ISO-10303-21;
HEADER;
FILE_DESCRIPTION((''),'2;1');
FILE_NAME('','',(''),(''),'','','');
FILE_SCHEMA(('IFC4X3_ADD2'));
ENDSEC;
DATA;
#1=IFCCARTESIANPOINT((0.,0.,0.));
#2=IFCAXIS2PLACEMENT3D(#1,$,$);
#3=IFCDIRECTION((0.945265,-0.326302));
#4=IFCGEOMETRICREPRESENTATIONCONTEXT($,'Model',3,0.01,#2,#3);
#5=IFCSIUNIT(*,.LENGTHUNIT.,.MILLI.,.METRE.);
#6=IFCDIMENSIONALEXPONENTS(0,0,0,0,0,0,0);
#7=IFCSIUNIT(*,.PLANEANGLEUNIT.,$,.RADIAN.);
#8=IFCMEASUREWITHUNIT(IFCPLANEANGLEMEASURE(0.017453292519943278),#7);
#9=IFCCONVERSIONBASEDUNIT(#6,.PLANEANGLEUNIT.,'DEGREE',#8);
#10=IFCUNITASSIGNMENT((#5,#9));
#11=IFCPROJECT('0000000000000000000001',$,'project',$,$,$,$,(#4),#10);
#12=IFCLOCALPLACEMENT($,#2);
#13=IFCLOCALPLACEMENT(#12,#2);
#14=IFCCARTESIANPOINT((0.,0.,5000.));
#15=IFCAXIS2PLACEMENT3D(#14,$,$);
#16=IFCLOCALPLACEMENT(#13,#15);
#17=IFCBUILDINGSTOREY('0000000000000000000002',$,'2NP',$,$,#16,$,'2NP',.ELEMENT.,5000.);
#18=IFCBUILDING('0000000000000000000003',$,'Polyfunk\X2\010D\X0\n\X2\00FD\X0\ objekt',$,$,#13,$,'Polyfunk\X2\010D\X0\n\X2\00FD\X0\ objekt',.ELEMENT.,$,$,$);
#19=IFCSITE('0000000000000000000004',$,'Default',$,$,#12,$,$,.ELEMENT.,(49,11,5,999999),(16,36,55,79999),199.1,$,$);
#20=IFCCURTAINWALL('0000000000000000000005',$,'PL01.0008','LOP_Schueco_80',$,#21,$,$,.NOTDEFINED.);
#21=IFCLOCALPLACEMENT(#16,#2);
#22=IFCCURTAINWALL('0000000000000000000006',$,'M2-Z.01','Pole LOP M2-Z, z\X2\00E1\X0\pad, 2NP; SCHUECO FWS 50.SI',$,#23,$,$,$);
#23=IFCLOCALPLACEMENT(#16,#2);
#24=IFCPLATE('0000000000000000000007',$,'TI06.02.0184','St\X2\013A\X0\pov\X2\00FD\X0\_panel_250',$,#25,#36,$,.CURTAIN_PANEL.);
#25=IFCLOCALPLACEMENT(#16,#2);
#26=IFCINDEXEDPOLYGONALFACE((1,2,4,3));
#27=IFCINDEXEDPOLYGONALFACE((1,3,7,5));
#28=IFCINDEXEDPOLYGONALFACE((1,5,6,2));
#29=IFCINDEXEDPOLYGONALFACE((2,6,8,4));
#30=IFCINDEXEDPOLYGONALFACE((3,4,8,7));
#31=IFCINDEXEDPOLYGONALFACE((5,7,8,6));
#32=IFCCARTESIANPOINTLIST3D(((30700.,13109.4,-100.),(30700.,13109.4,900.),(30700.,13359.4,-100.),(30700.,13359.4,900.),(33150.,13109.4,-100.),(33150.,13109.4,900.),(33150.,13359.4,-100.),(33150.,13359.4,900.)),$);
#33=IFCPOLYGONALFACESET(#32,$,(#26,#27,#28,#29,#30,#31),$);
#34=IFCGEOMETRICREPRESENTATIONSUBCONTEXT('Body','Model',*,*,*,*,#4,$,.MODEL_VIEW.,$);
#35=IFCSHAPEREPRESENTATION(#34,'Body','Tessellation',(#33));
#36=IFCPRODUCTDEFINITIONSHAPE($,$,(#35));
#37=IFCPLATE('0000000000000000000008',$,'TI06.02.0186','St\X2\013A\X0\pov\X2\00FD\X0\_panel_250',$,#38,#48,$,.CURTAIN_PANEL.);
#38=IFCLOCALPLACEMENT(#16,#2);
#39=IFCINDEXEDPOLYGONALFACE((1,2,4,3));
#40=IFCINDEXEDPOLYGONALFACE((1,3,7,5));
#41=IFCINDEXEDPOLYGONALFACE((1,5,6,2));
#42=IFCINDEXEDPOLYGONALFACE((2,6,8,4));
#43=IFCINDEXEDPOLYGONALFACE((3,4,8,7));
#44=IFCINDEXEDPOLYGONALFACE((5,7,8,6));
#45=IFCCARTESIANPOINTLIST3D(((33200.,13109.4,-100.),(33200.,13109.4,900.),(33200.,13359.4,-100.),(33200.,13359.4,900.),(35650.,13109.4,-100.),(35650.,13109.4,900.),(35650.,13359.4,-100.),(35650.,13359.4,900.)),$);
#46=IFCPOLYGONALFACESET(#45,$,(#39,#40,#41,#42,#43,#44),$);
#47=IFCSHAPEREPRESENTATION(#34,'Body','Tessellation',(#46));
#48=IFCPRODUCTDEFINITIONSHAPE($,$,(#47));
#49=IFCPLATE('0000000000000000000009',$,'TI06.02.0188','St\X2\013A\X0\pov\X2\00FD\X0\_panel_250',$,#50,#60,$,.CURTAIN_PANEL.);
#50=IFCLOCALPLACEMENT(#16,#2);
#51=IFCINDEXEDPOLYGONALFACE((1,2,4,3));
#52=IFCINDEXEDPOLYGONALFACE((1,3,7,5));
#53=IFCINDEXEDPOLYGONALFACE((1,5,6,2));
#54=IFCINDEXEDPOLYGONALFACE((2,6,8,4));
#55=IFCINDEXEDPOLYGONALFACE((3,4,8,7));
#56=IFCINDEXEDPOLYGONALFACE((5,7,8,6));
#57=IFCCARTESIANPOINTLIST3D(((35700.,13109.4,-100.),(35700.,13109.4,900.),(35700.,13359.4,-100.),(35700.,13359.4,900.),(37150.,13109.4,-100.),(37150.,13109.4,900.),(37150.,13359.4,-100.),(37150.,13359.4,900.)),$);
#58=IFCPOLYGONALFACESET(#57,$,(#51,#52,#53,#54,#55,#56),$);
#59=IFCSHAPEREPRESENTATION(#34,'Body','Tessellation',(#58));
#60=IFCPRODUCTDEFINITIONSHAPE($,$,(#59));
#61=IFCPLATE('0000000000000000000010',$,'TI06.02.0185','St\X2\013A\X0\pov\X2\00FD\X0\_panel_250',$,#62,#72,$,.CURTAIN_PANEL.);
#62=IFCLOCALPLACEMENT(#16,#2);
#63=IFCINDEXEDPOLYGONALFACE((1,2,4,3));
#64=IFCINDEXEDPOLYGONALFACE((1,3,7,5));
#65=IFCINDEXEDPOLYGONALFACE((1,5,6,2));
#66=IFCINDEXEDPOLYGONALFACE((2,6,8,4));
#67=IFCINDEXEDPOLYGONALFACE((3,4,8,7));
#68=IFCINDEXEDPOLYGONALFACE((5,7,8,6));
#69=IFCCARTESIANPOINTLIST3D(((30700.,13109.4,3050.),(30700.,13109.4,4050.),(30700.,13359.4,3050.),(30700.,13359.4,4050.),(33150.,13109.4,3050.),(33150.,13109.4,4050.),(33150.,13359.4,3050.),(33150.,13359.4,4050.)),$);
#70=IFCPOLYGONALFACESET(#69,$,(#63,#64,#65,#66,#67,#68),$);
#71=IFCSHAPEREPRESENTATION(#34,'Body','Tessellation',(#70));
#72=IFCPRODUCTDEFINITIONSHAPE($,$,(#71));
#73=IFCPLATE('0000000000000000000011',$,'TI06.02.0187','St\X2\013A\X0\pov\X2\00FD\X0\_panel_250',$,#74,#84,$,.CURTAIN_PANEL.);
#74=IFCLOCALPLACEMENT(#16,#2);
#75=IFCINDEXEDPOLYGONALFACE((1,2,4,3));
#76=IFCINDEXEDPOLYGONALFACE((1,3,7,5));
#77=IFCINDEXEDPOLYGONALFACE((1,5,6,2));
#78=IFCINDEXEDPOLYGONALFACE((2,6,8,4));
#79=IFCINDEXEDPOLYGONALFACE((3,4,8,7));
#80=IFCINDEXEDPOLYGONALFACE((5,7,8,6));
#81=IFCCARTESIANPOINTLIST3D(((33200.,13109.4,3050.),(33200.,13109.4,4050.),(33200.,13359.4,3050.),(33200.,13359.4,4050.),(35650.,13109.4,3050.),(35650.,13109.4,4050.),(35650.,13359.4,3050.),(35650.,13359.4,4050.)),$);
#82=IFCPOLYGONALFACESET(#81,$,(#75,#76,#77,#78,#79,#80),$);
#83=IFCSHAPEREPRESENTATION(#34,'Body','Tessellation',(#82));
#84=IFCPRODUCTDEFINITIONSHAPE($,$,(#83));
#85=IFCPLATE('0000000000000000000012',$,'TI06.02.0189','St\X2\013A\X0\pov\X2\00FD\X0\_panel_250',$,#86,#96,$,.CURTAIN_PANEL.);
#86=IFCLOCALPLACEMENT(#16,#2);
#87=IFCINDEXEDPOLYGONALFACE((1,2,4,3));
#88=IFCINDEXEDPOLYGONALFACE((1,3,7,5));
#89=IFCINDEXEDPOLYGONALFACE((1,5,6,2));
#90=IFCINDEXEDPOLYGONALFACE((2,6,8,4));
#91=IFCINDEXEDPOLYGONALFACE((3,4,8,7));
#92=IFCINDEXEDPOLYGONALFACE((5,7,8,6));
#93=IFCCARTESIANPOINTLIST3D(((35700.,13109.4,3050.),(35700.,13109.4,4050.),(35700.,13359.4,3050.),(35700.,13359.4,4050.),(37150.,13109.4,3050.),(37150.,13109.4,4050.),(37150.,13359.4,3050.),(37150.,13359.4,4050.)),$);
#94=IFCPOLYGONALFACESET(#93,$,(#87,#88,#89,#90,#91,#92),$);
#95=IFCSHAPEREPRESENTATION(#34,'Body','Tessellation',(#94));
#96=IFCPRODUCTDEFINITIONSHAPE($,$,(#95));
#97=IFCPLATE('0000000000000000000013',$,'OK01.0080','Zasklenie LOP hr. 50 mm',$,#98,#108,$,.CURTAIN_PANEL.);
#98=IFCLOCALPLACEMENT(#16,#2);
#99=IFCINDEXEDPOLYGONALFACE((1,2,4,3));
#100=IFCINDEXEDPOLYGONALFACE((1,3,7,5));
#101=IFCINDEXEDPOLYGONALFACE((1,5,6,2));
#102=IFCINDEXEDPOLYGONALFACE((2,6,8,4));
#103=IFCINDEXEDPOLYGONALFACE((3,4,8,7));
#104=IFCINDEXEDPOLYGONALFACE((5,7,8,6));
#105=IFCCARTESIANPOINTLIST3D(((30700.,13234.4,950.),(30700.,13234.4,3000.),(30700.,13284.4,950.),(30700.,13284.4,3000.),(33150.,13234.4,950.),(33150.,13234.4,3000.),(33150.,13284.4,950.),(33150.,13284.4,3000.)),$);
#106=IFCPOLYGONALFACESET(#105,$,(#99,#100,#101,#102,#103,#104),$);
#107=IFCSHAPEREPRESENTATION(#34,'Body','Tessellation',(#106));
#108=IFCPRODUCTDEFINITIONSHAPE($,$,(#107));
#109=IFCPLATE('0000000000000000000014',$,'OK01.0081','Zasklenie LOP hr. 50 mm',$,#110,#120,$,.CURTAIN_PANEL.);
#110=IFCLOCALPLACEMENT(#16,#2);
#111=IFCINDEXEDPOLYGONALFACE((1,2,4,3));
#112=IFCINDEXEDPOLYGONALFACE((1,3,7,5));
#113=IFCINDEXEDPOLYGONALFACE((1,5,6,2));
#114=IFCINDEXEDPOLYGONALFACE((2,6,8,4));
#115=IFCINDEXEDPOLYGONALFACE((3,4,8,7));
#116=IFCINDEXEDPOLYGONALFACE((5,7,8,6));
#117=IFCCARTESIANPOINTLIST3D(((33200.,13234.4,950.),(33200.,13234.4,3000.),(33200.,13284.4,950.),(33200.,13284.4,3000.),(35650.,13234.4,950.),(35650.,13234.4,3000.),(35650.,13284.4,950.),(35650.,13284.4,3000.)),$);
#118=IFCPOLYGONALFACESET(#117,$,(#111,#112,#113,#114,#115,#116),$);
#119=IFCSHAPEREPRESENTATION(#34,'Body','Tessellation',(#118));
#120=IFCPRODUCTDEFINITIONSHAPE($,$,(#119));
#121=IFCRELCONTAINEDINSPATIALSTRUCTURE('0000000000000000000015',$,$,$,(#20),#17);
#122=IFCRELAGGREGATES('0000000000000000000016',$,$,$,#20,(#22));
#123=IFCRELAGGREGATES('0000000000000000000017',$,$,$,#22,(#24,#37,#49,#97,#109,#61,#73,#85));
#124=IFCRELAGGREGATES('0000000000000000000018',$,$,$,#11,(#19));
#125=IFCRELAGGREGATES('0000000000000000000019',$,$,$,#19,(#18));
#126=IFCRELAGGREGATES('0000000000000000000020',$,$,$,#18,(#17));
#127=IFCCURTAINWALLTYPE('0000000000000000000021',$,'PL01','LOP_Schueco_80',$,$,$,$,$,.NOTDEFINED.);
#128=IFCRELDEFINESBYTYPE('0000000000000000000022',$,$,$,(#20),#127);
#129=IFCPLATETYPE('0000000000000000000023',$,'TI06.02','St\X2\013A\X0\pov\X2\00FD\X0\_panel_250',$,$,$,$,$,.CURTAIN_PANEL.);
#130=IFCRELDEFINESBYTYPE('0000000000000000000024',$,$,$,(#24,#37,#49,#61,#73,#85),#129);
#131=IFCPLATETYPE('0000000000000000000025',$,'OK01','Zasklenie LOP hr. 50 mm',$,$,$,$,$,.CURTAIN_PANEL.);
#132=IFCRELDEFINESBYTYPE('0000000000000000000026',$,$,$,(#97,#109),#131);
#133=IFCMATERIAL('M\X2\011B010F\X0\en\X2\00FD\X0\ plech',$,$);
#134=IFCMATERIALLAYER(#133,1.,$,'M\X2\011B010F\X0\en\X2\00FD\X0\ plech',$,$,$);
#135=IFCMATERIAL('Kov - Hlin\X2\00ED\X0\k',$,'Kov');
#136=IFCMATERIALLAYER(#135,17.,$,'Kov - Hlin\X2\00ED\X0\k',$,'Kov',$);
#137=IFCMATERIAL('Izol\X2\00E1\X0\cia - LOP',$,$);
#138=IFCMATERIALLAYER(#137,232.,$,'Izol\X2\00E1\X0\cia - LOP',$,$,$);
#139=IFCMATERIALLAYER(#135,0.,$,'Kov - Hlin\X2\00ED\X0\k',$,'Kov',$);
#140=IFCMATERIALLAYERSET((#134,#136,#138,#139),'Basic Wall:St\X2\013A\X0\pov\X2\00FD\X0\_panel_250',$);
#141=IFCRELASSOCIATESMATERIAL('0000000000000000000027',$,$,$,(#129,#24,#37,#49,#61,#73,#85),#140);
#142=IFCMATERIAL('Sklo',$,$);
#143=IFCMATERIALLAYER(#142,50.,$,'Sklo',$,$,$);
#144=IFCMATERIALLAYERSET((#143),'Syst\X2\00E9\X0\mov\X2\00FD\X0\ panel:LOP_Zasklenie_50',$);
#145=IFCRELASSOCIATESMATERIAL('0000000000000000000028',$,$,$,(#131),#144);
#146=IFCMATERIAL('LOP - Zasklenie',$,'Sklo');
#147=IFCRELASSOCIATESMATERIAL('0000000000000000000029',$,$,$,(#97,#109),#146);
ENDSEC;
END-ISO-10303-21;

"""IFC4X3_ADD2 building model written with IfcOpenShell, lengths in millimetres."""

from ifc_helpers import new_model, entity, si_unit, converted_unit, direction, frame, frame_2d, origin, origin_2d_with_axis, place, context, subcontext, project, spatial, rectangle, extrude, source, transform, mapped, material, layer, layer_set, layer_usage, type_object, type_shapes, element, aggregate, save


model = new_model("IFC4X3_ADD2")

# Units and contexts
model_context = context("Model", 3, precision=0.01, world=origin(), true_north=direction((0.945265, -0.326302)))
body_context = subcontext(model_context, "Body", "Model", "MODEL_VIEW")
ifc_project = project(units=[si_unit("LENGTHUNIT", "METRE", prefix="MILLI"), converted_unit("PLANEANGLEUNIT", "DEGREE", entity("IfcPlaneAngleMeasure", 0.017453292519943278), si_unit("PLANEANGLEUNIT", "RADIAN"), dimensions=[0, 0, 0, 0, 0, 0, 0])], contexts=[model_context])

# Site, building, storey
site_placement = place(None, origin())
site = spatial("IfcSite", under=ifc_project, at=site_placement, Name="Default", CompositionType="ELEMENT", RefLatitude=(49, 11, 5, 999999), RefLongitude=(16, 36, 55, 79999), RefElevation=199.1)
building_placement = place(site_placement, origin())
building = spatial("IfcBuilding", under=site, at=building_placement, Name="Polyfunkčný objekt", LongName="Polyfunkčný objekt", CompositionType="ELEMENT")
storey_placement = place(building_placement, frame((0.0, 0.0, 5000.0)))
storey = spatial("IfcBuildingStorey", under=building, at=storey_placement, Name="2NP", LongName="2NP", CompositionType="ELEMENT", Elevation=5000.0)

# Curtain walls, plates
curtain_wall_type = type_object("IfcCurtainWallType", Name="PL01", Description="LOP_Schueco_80", PredefinedType="NOTDEFINED")
curtain_wall_1_placement = place(storey_placement, frame((0.0, 0.0, -5000.0)))
curtain_wall_1 = element("IfcCurtainWall", 1, at=curtain_wall_1_placement, inside=storey, type_object=curtain_wall_type, Name="PL01.0008", Description="LOP_Schueco_80", PredefinedType="NOTDEFINED")
curtain_wall_2 = element("IfcCurtainWall", 2, Name="M2-Z.01", Description="Pole LOP M2-Z, západ, 2NP; SCHUECO FWS 50.SI")
aggregate(curtain_wall_1, [curtain_wall_2])
ifc_material_1 = material(Name="Měďený plech")
ifc_layer_1 = layer(ifc_material_1, 1.0, Name="Měďený plech")
ifc_material_2 = material(Name="Kov - Hliník", Category="Kov")
ifc_layer_2 = layer(ifc_material_2, 17.0, Name="Kov - Hliník", Category="Kov")
ifc_material_3 = material(Name="Izolácia - LOP")
ifc_layer_3 = layer(ifc_material_3, 232.0, Name="Izolácia - LOP")
ifc_layer_4 = layer(ifc_material_2, 0.0, Name="Kov - Hliník", Category="Kov")
ifc_layer_set_1 = layer_set([ifc_layer_1, ifc_layer_2, ifc_layer_3, ifc_layer_4], Name="Basic Wall:Stĺpový_panel_250")
ifc_layer_usage_1 = layer_usage(ifc_layer_set_1, "AXIS2", "NEGATIVE", 125.0)
plate_type_1 = type_object("IfcPlateType", Name="TI06.02", Description="Stĺpový_panel_250", PredefinedType="CURTAIN_PANEL", material=ifc_layer_set_1)
plate_1_placement = place(storey_placement, frame((30700.0, 13234.4, -100.0)))
plate_1 = element("IfcPlate", 3, at=plate_1_placement, type_object=plate_type_1, material=ifc_layer_usage_1, Name="TI06.02.0184", Description="Stĺpový_panel_250", PredefinedType="CURTAIN_PANEL", context=body_context, shape_type="SweptSolid", body=[
    extrude(rectangle(XDim=250.0, YDim=2450.0, at=frame_2d((0.0, 0.0), x_axis=(1.0, 0.0))), frame((1225.0, 0.0, 0.0), z_axis=(0.0, 0.0, 1.0), x_axis=(0.0, 1.0, 0.0)), (0.0, 0.0, 1.0), 1000.0),
])
ifc_layer_usage_2 = layer_usage(ifc_layer_set_1, "AXIS2", "NEGATIVE", 125.0)
plate_2_placement = place(storey_placement, frame((33200.0, 13234.4, -100.0)))
plate_2 = element("IfcPlate", 4, at=plate_2_placement, type_object=plate_type_1, material=ifc_layer_usage_2, Name="TI06.02.0186", Description="Stĺpový_panel_250", PredefinedType="CURTAIN_PANEL", context=body_context, shape_type="SweptSolid", body=[
    extrude(rectangle(XDim=250.0, YDim=2450.0, at=frame_2d((0.0, 0.0), x_axis=(1.0, 0.0))), frame((1225.0, 0.0, 0.0), z_axis=(0.0, 0.0, 1.0), x_axis=(0.0, 1.0, 0.0)), (0.0, 0.0, 1.0), 1000.0),
])
ifc_layer_usage_3 = layer_usage(ifc_layer_set_1, "AXIS2", "NEGATIVE", 125.0)
plate_3_placement = place(storey_placement, frame((35700.0, 13234.4, -100.0)))
plate_3 = element("IfcPlate", 5, at=plate_3_placement, type_object=plate_type_1, material=ifc_layer_usage_3, Name="TI06.02.0188", Description="Stĺpový_panel_250", PredefinedType="CURTAIN_PANEL", context=body_context, shape_type="SweptSolid", body=[
    extrude(rectangle(XDim=250.0, YDim=1450.0, at=origin_2d_with_axis()), frame((725.0, 0.0, 0.0), z_axis=(0.0, 0.0, 1.0), x_axis=(0.0, 1.0, 0.0)), (0.0, 0.0, 1.0), 1000.0),
])
ifc_layer_usage_4 = layer_usage(ifc_layer_set_1, "AXIS2", "NEGATIVE", 125.0)
plate_4_placement = place(storey_placement, frame((30700.0, 13234.4, 3050.0)))
plate_4 = element("IfcPlate", 6, at=plate_4_placement, type_object=plate_type_1, material=ifc_layer_usage_4, Name="TI06.02.0185", Description="Stĺpový_panel_250", PredefinedType="CURTAIN_PANEL", context=body_context, shape_type="SweptSolid", body=[
    extrude(rectangle(XDim=250.0, YDim=2450.0, at=frame_2d((0.0, 0.0), x_axis=(1.0, 0.0))), frame((1225.0, 0.0, 0.0), z_axis=(0.0, 0.0, 1.0), x_axis=(0.0, 1.0, 0.0)), (0.0, 0.0, 1.0), 1000.0),
])
ifc_layer_usage_5 = layer_usage(ifc_layer_set_1, "AXIS2", "NEGATIVE", 125.0)
plate_5_placement = place(storey_placement, frame((33200.0, 13234.4, 3050.0)))
plate_5 = element("IfcPlate", 7, at=plate_5_placement, type_object=plate_type_1, material=ifc_layer_usage_5, Name="TI06.02.0187", Description="Stĺpový_panel_250", PredefinedType="CURTAIN_PANEL", context=body_context, shape_type="SweptSolid", body=[
    extrude(rectangle(XDim=250.0, YDim=2450.0, at=frame_2d((0.0, 0.0), x_axis=(1.0, 0.0))), frame((1225.0, 0.0, 0.0), z_axis=(0.0, 0.0, 1.0), x_axis=(0.0, 1.0, 0.0)), (0.0, 0.0, 1.0), 1000.0),
])
ifc_layer_usage_6 = layer_usage(ifc_layer_set_1, "AXIS2", "NEGATIVE", 125.0)
plate_6_placement = place(storey_placement, frame((35700.0, 13234.4, 3050.0)))
plate_6 = element("IfcPlate", 8, at=plate_6_placement, type_object=plate_type_1, material=ifc_layer_usage_6, Name="TI06.02.0189", Description="Stĺpový_panel_250", PredefinedType="CURTAIN_PANEL", context=body_context, shape_type="SweptSolid", body=[
    extrude(rectangle(XDim=250.0, YDim=1450.0, at=origin_2d_with_axis()), frame((725.0, 0.0, 0.0), z_axis=(0.0, 0.0, 1.0), x_axis=(0.0, 1.0, 0.0)), (0.0, 0.0, 1.0), 1000.0),
])
ifc_material_4 = material(Name="LOP - Zasklenie", Category="Sklo")
ifc_material_5 = material(Name="Sklo")
ifc_layer_5 = layer(ifc_material_5, 50.0, Name="Sklo")
ifc_layer_set_2 = layer_set([ifc_layer_5], Name="Systémový panel:LOP_Zasklenie_50")
plate_type_2 = type_object("IfcPlateType", Name="OK01", Description="Zasklenie LOP hr. 50 mm", PredefinedType="CURTAIN_PANEL", material=ifc_layer_set_2)
shared_shape_1 = source(origin(), body_context, "Body", "SweptSolid", [
    extrude(rectangle(XDim=50.0, YDim=2450.0, at=origin_2d_with_axis()), frame((0.0, 25.0, 0.0), z_axis=(0.0, 0.0, 1.0), x_axis=(0.0, 1.0, 0.0)), (0.0, 0.0, 1.0), 2050.0),
])
type_shapes(plate_type_2, [shared_shape_1])
plate_7_placement = place(curtain_wall_1_placement, frame((31925.0, 13234.4, 5950.0)))
plate_7 = element("IfcPlate", 9, at=plate_7_placement, type_object=plate_type_2, material=ifc_material_4, Name="OK01.0080", Description="Zasklenie LOP hr. 50 mm", PredefinedType="CURTAIN_PANEL", context=body_context, shape_type="MappedRepresentation", body=[
    mapped(shared_shape_1, transform((0.0, 0.0, 0.0), scale=1.0)),
])
plate_8_placement = place(curtain_wall_1_placement, frame((34425.0, 13234.4, 5950.0)))
plate_8 = element("IfcPlate", 10, at=plate_8_placement, type_object=plate_type_2, material=ifc_material_4, Name="OK01.0081", Description="Zasklenie LOP hr. 50 mm", PredefinedType="CURTAIN_PANEL", context=body_context, shape_type="MappedRepresentation", body=[
    mapped(shared_shape_1, transform((0.0, 0.0, 0.0), scale=1.0)),
])
aggregate(curtain_wall_2, [plate_1, plate_2, plate_3, plate_7, plate_8, plate_4, plate_5, plate_6])

save(model, "model.ifc")
